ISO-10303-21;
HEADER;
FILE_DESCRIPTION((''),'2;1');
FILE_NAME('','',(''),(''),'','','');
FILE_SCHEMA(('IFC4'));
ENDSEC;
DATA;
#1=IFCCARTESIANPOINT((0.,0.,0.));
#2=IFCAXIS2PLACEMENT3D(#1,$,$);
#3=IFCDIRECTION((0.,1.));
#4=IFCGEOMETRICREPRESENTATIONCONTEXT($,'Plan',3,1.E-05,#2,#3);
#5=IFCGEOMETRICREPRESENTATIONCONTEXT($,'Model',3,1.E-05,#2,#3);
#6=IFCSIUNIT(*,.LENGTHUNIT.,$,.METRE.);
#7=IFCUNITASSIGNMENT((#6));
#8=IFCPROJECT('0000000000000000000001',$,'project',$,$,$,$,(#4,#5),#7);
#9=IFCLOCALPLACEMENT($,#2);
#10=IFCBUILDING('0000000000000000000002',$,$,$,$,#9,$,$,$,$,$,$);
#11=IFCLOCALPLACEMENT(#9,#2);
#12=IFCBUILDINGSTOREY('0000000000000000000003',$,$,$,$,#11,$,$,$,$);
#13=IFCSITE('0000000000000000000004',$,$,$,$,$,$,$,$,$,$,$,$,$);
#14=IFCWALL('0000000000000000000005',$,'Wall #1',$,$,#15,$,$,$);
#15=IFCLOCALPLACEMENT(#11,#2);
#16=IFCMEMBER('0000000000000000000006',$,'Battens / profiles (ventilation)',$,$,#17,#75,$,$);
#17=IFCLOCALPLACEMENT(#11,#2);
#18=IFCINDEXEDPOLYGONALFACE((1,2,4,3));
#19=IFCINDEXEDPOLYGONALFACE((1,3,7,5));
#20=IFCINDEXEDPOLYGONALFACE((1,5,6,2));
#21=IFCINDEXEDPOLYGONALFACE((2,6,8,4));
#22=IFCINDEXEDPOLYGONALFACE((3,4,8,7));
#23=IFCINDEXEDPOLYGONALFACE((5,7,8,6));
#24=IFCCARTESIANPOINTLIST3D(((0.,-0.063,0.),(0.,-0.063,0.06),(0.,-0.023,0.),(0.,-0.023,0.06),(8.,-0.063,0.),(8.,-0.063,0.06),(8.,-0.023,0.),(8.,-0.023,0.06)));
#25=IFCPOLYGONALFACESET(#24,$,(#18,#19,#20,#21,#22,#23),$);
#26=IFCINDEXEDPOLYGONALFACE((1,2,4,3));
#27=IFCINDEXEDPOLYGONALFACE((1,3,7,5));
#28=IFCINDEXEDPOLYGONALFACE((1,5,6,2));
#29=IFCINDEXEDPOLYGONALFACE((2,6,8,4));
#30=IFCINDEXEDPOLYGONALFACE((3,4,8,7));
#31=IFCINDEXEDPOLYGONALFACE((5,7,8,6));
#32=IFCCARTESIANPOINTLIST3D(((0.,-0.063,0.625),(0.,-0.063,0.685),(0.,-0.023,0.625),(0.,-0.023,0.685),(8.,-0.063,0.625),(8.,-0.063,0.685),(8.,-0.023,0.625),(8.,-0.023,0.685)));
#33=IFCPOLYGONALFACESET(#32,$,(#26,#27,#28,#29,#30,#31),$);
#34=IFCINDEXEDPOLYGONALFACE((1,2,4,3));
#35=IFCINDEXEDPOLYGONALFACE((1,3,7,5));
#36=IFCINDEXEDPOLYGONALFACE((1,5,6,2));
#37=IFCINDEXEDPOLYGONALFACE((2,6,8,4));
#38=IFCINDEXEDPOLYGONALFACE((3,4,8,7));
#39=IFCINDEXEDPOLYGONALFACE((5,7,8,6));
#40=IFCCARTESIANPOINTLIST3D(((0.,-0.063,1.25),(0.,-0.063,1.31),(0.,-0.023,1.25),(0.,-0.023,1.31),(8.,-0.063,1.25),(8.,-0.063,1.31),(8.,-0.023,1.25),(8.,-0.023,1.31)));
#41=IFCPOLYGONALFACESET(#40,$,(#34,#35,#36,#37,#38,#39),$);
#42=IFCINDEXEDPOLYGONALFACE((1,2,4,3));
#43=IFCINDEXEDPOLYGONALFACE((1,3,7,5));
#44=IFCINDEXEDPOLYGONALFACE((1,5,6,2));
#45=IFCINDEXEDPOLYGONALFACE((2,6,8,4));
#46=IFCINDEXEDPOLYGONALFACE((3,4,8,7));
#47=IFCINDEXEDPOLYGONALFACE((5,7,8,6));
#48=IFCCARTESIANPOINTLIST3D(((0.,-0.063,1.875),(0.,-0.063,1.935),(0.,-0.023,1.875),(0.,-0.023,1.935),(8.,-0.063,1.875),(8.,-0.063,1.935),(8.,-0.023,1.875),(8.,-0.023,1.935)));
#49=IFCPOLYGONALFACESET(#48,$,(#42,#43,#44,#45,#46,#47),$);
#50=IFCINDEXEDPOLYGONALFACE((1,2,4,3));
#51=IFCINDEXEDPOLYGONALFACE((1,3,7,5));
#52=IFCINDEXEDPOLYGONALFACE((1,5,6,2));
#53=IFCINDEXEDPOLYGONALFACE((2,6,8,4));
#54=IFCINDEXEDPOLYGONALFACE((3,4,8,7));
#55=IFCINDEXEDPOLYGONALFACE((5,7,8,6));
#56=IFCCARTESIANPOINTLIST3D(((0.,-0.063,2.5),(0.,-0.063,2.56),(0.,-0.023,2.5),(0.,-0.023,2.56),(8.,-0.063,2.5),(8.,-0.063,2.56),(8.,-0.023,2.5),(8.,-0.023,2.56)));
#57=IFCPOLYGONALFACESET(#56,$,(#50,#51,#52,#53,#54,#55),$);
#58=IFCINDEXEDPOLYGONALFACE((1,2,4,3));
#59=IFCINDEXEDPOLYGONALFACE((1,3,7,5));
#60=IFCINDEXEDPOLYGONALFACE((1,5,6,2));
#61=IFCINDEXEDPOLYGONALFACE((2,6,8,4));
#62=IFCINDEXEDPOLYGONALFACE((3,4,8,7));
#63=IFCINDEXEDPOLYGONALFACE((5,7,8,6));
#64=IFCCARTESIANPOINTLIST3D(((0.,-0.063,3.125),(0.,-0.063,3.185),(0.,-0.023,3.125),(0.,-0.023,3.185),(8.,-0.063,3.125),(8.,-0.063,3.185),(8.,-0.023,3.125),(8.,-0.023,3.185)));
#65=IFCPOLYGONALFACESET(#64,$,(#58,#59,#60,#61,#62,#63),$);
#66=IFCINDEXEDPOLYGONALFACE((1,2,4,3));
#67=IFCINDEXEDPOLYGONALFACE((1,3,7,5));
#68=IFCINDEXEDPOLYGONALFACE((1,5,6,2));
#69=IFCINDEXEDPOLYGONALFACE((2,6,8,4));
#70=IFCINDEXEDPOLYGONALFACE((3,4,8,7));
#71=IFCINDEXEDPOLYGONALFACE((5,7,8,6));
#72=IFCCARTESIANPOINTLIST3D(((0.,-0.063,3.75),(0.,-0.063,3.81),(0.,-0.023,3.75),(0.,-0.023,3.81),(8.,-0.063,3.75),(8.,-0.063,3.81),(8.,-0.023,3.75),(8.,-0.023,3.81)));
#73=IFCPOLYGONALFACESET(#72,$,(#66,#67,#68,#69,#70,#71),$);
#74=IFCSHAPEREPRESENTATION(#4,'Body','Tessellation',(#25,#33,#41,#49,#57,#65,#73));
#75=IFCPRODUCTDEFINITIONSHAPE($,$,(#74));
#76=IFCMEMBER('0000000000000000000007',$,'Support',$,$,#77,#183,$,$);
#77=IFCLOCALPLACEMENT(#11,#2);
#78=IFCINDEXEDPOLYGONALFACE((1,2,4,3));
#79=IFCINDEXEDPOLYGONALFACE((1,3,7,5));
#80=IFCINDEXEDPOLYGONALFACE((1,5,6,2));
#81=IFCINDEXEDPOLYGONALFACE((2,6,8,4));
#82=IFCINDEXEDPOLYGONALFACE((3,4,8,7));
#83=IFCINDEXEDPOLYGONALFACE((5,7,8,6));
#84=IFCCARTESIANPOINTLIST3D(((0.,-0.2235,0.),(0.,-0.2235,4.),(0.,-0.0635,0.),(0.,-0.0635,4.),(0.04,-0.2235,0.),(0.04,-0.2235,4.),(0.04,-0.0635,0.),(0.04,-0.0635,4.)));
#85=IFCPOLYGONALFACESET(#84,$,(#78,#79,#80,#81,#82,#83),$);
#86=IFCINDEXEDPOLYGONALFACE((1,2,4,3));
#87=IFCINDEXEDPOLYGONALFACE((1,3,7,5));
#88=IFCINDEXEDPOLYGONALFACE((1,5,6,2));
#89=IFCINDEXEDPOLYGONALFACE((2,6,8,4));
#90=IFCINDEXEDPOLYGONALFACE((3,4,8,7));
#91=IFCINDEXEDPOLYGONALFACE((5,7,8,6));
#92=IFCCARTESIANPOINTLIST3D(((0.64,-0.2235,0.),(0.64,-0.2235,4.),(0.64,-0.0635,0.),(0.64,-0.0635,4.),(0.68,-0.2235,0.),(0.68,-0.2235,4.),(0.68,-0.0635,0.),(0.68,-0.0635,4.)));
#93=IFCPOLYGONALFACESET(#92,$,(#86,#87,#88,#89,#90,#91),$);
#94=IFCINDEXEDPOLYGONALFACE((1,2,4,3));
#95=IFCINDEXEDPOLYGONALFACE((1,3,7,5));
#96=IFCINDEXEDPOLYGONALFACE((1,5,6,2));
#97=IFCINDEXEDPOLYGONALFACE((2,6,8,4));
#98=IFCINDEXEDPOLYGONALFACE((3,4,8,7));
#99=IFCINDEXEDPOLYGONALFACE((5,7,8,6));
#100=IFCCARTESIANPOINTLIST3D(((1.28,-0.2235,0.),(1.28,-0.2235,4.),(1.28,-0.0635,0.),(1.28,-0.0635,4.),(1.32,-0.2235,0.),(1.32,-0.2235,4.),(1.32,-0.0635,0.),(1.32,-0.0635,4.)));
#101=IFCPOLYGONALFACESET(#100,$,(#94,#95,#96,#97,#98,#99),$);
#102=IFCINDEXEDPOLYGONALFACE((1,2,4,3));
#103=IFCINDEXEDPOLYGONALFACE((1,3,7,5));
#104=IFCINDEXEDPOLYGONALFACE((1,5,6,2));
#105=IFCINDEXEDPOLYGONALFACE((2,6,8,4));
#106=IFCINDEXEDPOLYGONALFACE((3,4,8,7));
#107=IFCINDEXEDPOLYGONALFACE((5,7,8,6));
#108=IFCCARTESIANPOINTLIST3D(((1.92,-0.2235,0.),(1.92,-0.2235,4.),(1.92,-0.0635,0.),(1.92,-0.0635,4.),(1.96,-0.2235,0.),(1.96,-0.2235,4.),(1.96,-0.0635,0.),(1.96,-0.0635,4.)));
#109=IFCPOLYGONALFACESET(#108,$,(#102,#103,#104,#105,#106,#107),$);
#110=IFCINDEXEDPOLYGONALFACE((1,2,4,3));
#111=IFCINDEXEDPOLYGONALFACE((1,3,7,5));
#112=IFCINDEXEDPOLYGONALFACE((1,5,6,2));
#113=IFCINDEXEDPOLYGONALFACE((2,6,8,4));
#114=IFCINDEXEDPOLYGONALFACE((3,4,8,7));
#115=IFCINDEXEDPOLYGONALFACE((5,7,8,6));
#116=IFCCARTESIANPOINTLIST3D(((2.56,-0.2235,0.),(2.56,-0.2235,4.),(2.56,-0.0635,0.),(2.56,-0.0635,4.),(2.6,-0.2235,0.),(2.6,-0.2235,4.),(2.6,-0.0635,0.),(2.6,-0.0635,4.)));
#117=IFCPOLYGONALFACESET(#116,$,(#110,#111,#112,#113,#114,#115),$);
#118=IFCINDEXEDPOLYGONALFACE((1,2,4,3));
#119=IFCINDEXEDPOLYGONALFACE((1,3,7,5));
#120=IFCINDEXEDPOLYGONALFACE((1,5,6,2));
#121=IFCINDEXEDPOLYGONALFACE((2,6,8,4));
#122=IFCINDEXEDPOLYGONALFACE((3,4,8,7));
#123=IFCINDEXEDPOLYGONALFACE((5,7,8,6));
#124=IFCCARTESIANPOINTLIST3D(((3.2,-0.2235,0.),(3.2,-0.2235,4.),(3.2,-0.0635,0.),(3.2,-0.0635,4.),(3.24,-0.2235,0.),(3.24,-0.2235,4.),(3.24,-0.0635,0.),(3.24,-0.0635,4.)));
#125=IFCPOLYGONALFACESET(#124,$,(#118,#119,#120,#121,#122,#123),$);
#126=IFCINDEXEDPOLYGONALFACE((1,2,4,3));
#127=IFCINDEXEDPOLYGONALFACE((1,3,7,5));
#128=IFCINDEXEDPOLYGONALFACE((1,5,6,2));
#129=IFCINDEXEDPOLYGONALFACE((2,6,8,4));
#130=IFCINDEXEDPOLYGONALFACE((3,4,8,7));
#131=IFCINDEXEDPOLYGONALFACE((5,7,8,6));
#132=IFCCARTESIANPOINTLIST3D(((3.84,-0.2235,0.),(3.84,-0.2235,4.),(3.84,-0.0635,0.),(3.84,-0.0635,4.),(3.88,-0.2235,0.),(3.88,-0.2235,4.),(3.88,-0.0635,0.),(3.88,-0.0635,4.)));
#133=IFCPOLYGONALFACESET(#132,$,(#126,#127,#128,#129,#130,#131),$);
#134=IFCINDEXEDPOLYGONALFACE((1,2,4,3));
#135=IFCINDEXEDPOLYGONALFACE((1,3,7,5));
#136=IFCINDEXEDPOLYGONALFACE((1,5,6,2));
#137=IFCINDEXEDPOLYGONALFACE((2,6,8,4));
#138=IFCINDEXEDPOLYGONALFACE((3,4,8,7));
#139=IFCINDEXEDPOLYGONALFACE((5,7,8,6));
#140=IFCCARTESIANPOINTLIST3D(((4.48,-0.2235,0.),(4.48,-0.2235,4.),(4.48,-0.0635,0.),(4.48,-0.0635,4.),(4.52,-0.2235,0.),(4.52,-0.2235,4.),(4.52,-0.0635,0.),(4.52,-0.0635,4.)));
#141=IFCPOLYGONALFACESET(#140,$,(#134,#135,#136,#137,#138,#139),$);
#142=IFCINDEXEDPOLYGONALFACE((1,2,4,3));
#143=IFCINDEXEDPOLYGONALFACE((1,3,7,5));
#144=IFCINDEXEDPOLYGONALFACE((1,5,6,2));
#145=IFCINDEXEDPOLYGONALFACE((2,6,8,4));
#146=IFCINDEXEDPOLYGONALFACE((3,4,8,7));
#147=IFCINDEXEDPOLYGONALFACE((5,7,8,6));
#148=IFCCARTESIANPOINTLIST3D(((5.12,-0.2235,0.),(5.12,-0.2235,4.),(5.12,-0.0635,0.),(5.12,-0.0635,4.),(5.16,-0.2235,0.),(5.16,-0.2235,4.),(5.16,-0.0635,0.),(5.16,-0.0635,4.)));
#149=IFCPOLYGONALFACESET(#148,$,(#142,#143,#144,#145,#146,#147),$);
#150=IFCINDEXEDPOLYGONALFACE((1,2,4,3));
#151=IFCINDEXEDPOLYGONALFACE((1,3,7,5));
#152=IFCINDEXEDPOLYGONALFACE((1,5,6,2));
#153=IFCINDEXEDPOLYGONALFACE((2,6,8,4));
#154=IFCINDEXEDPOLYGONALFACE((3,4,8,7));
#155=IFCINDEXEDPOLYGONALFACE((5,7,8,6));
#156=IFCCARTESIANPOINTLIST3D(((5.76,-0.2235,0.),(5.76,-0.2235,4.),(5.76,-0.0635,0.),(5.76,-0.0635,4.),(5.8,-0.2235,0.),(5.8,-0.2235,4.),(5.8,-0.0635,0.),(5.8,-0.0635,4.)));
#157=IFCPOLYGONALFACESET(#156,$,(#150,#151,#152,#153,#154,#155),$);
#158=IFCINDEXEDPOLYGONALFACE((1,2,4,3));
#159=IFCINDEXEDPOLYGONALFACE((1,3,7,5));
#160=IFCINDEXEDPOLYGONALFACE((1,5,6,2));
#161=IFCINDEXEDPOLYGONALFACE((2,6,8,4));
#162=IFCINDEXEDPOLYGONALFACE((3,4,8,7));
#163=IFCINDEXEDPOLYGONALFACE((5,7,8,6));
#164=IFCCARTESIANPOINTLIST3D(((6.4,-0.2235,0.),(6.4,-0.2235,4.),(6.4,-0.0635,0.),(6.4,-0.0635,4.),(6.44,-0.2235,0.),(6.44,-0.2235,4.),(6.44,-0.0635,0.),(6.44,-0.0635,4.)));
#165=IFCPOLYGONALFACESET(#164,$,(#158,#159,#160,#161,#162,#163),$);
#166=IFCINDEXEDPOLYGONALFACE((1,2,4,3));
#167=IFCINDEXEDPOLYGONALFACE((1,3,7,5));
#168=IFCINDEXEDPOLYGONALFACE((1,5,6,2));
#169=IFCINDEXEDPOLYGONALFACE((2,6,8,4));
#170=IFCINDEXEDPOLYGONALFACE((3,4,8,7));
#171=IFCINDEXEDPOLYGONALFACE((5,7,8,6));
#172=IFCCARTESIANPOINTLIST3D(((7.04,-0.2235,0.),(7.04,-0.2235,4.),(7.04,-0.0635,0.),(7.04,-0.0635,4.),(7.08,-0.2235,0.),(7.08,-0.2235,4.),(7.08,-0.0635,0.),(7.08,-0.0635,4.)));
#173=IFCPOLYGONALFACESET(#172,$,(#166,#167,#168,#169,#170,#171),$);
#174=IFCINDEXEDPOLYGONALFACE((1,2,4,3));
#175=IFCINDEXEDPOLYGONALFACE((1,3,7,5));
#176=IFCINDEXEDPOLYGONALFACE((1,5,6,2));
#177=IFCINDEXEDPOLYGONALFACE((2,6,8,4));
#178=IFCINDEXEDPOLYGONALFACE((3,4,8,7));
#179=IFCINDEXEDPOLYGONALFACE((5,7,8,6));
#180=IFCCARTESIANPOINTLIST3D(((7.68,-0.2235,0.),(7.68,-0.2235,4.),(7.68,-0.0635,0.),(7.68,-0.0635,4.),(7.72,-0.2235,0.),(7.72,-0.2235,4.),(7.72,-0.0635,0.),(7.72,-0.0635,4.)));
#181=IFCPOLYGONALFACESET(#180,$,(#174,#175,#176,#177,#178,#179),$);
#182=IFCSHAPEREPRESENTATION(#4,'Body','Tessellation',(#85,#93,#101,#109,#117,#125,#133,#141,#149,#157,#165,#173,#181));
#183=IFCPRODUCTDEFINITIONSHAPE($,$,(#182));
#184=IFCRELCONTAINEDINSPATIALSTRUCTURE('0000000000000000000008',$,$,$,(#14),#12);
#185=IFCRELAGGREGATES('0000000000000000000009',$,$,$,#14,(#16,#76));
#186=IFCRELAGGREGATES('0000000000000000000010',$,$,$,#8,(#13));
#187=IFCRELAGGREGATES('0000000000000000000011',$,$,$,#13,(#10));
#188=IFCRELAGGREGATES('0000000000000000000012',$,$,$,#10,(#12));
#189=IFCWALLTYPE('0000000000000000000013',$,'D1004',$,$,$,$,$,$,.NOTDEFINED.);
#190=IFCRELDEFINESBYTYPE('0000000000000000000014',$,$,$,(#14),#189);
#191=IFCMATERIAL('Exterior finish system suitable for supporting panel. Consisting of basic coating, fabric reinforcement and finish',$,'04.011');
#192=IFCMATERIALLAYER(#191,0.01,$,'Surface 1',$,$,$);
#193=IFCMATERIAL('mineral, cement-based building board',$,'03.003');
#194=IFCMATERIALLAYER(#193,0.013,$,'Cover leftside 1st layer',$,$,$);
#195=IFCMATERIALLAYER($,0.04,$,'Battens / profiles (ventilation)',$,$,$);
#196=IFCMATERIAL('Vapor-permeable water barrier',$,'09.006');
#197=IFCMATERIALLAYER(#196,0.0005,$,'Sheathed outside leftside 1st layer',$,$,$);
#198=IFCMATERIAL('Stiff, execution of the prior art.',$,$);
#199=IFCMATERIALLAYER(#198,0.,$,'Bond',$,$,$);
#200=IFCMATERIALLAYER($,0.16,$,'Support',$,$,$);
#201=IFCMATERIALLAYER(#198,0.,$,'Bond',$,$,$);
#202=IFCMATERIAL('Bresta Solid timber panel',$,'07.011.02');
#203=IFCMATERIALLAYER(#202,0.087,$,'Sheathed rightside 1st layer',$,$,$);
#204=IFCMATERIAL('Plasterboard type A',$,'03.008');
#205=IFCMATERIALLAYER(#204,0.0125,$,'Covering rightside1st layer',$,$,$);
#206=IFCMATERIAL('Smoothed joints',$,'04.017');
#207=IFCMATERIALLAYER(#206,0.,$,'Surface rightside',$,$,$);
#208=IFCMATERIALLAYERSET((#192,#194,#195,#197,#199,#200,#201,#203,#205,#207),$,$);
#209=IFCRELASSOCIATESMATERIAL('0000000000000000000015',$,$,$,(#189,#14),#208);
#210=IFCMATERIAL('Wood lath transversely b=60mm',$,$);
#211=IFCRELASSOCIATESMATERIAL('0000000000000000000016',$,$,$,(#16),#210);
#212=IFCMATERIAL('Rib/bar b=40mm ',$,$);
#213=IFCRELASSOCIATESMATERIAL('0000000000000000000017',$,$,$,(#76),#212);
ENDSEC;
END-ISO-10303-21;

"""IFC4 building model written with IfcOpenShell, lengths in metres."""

from ifc_helpers import new_model, si_unit, direction, frame, frame_2d, origin, place, context, project, spatial, rectangle, extrude, material, layer, layer_set, type_object, element, aggregate, save


model = new_model("IFC4")

# Units and contexts
plan_context = context("Plan", 3, precision=1e-05, world=origin(), true_north=direction((0.0, 1.0)))
model_context = context("Model", 3, precision=1e-05, world=origin(), true_north=direction((0.0, 1.0)))
ifc_project = project(units=[si_unit("LENGTHUNIT", "METRE")], contexts=[plan_context, model_context])

# Site, building, storey
site = spatial("IfcSite", under=ifc_project)
building_placement = place(None, origin())
building = spatial("IfcBuilding", under=site, at=building_placement)
storey_placement = place(building_placement, origin())
storey = spatial("IfcBuildingStorey", under=building, at=storey_placement)

# Wall, members
ifc_material_1 = material(Name="Exterior finish system suitable for supporting panel. Consisting of basic coating, fabric reinforcement and finish", Category="04.011")
ifc_layer_1 = layer(ifc_material_1, 0.01, Name="Surface 1")
ifc_material_2 = material(Name="mineral, cement-based building board", Category="03.003")
ifc_layer_2 = layer(ifc_material_2, 0.013, Name="Cover leftside 1st layer")
ifc_layer_3 = layer(None, 0.04, Name="Battens / profiles (ventilation)")
ifc_material_3 = material(Name="Vapor-permeable water barrier", Category="09.006")
ifc_layer_4 = layer(ifc_material_3, 0.0005, Name="Sheathed outside leftside 1st layer")
ifc_material_4 = material(Name="Stiff, execution of the prior art.")
ifc_layer_5 = layer(ifc_material_4, 0.0, Name="Bond")
ifc_layer_6 = layer(None, 0.16, Name="Support")
ifc_layer_7 = layer(ifc_material_4, 0.0, Name="Bond")
ifc_material_5 = material(Name="Bresta Solid timber panel", Category="07.011.02")
ifc_layer_8 = layer(ifc_material_5, 0.087, Name="Sheathed rightside 1st layer")
ifc_material_6 = material(Name="Plasterboard type A", Category="03.008")
ifc_layer_9 = layer(ifc_material_6, 0.0125, Name="Covering rightside1st layer")
ifc_material_7 = material(Name="Smoothed joints", Category="04.017")
ifc_layer_10 = layer(ifc_material_7, 0.0, Name="Surface rightside")
ifc_layer_set = layer_set([ifc_layer_1, ifc_layer_2, ifc_layer_3, ifc_layer_4, ifc_layer_5, ifc_layer_6, ifc_layer_7, ifc_layer_8, ifc_layer_9, ifc_layer_10])
wall_type = type_object("IfcWallType", Name="D1004", PredefinedType="NOTDEFINED", material=ifc_layer_set)
wall_placement = place(None, frame((0.0, 0.0, 0.0), z_axis=(0.0, -1.0, 0.0), x_axis=(1.0, 0.0, 0.0)))
wall = element("IfcWall", 1, at=wall_placement, inside=storey, type_object=wall_type, material=ifc_layer_set, Name="Wall #1")
ifc_material_8 = material(Name="Wood lath transversely b=60mm")
member_1_placement = place(wall_placement, origin())
member_1 = element("IfcMember", 2, at=member_1_placement, material=ifc_material_8, Name="Battens / profiles (ventilation)", context=plan_context, shape_type="SweptSolid", body=[
    extrude(rectangle(XDim=0.06, YDim=0.04, at=frame_2d((0.03, 0.02), x_axis=(1.0, 0.0))), frame((0.0, 0.0, 0.023), z_axis=(1.0, 0.0, 0.0), x_axis=(0.0, 1.0, 0.0)), (0.0, 0.0, 1.0), 8.0),
    extrude(rectangle(XDim=0.06, YDim=0.04, at=frame_2d((0.03, 0.02), x_axis=(1.0, 0.0))), frame((0.0, 0.625, 0.023), z_axis=(1.0, 0.0, 0.0), x_axis=(0.0, 1.0, 0.0)), (0.0, 0.0, 1.0), 8.0),
    extrude(rectangle(XDim=0.06, YDim=0.04, at=frame_2d((0.03, 0.02), x_axis=(1.0, 0.0))), frame((0.0, 1.25, 0.023), z_axis=(1.0, 0.0, 0.0), x_axis=(0.0, 1.0, 0.0)), (0.0, 0.0, 1.0), 8.0),
    extrude(rectangle(XDim=0.06, YDim=0.04, at=frame_2d((0.03, 0.02), x_axis=(1.0, 0.0))), frame((0.0, 1.875, 0.023), z_axis=(1.0, 0.0, 0.0), x_axis=(0.0, 1.0, 0.0)), (0.0, 0.0, 1.0), 8.0),
    extrude(rectangle(XDim=0.06, YDim=0.04, at=frame_2d((0.03, 0.02), x_axis=(1.0, 0.0))), frame((0.0, 2.5, 0.023), z_axis=(1.0, 0.0, 0.0), x_axis=(0.0, 1.0, 0.0)), (0.0, 0.0, 1.0), 8.0),
    extrude(rectangle(XDim=0.06, YDim=0.04, at=frame_2d((0.03, 0.02), x_axis=(1.0, 0.0))), frame((0.0, 3.125, 0.023), z_axis=(1.0, 0.0, 0.0), x_axis=(0.0, 1.0, 0.0)), (0.0, 0.0, 1.0), 8.0),
    extrude(rectangle(XDim=0.06, YDim=0.04, at=frame_2d((0.03, 0.02), x_axis=(1.0, 0.0))), frame((0.0, 3.75, 0.023), z_axis=(1.0, 0.0, 0.0), x_axis=(0.0, 1.0, 0.0)), (0.0, 0.0, 1.0), 8.0),
])
ifc_material_9 = material(Name="Rib/bar b=40mm ")
member_2_placement = place(wall_placement, origin())
member_2 = element("IfcMember", 3, at=member_2_placement, material=ifc_material_9, Name="Support", context=plan_context, shape_type="SweptSolid", body=[
    extrude(rectangle(XDim=0.04, YDim=0.16, at=frame_2d((0.02, 0.08), x_axis=(1.0, 0.0))), frame((0.0, 4.0, 0.0635), z_axis=(0.0, -1.0, 0.0), x_axis=(1.0, 0.0, 0.0)), (0.0, 0.0, 1.0), 4.0),
    extrude(rectangle(XDim=0.04, YDim=0.16, at=frame_2d((0.02, 0.08), x_axis=(1.0, 0.0))), frame((0.64, 4.0, 0.0635), z_axis=(0.0, -1.0, 0.0), x_axis=(1.0, 0.0, 0.0)), (0.0, 0.0, 1.0), 4.0),
    extrude(rectangle(XDim=0.04, YDim=0.16, at=frame_2d((0.02, 0.08), x_axis=(1.0, 0.0))), frame((1.28, 4.0, 0.0635), z_axis=(0.0, -1.0, 0.0), x_axis=(1.0, 0.0, 0.0)), (0.0, 0.0, 1.0), 4.0),
    extrude(rectangle(XDim=0.04, YDim=0.16, at=frame_2d((0.02, 0.08), x_axis=(1.0, 0.0))), frame((1.92, 4.0, 0.0635), z_axis=(0.0, -1.0, 0.0), x_axis=(1.0, 0.0, 0.0)), (0.0, 0.0, 1.0), 4.0),
    extrude(rectangle(XDim=0.04, YDim=0.16, at=frame_2d((0.02, 0.08), x_axis=(1.0, 0.0))), frame((2.56, 4.0, 0.0635), z_axis=(0.0, -1.0, 0.0), x_axis=(1.0, 0.0, 0.0)), (0.0, 0.0, 1.0), 4.0),
    extrude(rectangle(XDim=0.04, YDim=0.16, at=frame_2d((0.02, 0.08), x_axis=(1.0, 0.0))), frame((3.2, 4.0, 0.0635), z_axis=(0.0, -1.0, 0.0), x_axis=(1.0, 0.0, 0.0)), (0.0, 0.0, 1.0), 4.0),
    extrude(rectangle(XDim=0.04, YDim=0.16, at=frame_2d((0.02, 0.08), x_axis=(1.0, 0.0))), frame((3.84, 4.0, 0.0635), z_axis=(0.0, -1.0, 0.0), x_axis=(1.0, 0.0, 0.0)), (0.0, 0.0, 1.0), 4.0),
    extrude(rectangle(XDim=0.04, YDim=0.16, at=frame_2d((0.02, 0.08), x_axis=(1.0, 0.0))), frame((4.48, 4.0, 0.0635), z_axis=(0.0, -1.0, 0.0), x_axis=(1.0, 0.0, 0.0)), (0.0, 0.0, 1.0), 4.0),
    extrude(rectangle(XDim=0.04, YDim=0.16, at=frame_2d((0.02, 0.08), x_axis=(1.0, 0.0))), frame((5.12, 4.0, 0.0635), z_axis=(0.0, -1.0, 0.0), x_axis=(1.0, 0.0, 0.0)), (0.0, 0.0, 1.0), 4.0),
    extrude(rectangle(XDim=0.04, YDim=0.16, at=frame_2d((0.02, 0.08), x_axis=(1.0, 0.0))), frame((5.76, 4.0, 0.0635), z_axis=(0.0, -1.0, 0.0), x_axis=(1.0, 0.0, 0.0)), (0.0, 0.0, 1.0), 4.0),
    extrude(rectangle(XDim=0.04, YDim=0.16, at=frame_2d((0.02, 0.08), x_axis=(1.0, 0.0))), frame((6.4, 4.0, 0.0635), z_axis=(0.0, -1.0, 0.0), x_axis=(1.0, 0.0, 0.0)), (0.0, 0.0, 1.0), 4.0),
    extrude(rectangle(XDim=0.04, YDim=0.16, at=frame_2d((0.02, 0.08), x_axis=(1.0, 0.0))), frame((7.04, 4.0, 0.0635), z_axis=(0.0, -1.0, 0.0), x_axis=(1.0, 0.0, 0.0)), (0.0, 0.0, 1.0), 4.0),
    extrude(rectangle(XDim=0.04, YDim=0.16, at=frame_2d((0.02, 0.08), x_axis=(1.0, 0.0))), frame((7.68, 4.0, 0.0635), z_axis=(0.0, -1.0, 0.0), x_axis=(1.0, 0.0, 0.0)), (0.0, 0.0, 1.0), 4.0),
])
aggregate(wall, [member_1, member_2])

save(model, "model.ifc")
